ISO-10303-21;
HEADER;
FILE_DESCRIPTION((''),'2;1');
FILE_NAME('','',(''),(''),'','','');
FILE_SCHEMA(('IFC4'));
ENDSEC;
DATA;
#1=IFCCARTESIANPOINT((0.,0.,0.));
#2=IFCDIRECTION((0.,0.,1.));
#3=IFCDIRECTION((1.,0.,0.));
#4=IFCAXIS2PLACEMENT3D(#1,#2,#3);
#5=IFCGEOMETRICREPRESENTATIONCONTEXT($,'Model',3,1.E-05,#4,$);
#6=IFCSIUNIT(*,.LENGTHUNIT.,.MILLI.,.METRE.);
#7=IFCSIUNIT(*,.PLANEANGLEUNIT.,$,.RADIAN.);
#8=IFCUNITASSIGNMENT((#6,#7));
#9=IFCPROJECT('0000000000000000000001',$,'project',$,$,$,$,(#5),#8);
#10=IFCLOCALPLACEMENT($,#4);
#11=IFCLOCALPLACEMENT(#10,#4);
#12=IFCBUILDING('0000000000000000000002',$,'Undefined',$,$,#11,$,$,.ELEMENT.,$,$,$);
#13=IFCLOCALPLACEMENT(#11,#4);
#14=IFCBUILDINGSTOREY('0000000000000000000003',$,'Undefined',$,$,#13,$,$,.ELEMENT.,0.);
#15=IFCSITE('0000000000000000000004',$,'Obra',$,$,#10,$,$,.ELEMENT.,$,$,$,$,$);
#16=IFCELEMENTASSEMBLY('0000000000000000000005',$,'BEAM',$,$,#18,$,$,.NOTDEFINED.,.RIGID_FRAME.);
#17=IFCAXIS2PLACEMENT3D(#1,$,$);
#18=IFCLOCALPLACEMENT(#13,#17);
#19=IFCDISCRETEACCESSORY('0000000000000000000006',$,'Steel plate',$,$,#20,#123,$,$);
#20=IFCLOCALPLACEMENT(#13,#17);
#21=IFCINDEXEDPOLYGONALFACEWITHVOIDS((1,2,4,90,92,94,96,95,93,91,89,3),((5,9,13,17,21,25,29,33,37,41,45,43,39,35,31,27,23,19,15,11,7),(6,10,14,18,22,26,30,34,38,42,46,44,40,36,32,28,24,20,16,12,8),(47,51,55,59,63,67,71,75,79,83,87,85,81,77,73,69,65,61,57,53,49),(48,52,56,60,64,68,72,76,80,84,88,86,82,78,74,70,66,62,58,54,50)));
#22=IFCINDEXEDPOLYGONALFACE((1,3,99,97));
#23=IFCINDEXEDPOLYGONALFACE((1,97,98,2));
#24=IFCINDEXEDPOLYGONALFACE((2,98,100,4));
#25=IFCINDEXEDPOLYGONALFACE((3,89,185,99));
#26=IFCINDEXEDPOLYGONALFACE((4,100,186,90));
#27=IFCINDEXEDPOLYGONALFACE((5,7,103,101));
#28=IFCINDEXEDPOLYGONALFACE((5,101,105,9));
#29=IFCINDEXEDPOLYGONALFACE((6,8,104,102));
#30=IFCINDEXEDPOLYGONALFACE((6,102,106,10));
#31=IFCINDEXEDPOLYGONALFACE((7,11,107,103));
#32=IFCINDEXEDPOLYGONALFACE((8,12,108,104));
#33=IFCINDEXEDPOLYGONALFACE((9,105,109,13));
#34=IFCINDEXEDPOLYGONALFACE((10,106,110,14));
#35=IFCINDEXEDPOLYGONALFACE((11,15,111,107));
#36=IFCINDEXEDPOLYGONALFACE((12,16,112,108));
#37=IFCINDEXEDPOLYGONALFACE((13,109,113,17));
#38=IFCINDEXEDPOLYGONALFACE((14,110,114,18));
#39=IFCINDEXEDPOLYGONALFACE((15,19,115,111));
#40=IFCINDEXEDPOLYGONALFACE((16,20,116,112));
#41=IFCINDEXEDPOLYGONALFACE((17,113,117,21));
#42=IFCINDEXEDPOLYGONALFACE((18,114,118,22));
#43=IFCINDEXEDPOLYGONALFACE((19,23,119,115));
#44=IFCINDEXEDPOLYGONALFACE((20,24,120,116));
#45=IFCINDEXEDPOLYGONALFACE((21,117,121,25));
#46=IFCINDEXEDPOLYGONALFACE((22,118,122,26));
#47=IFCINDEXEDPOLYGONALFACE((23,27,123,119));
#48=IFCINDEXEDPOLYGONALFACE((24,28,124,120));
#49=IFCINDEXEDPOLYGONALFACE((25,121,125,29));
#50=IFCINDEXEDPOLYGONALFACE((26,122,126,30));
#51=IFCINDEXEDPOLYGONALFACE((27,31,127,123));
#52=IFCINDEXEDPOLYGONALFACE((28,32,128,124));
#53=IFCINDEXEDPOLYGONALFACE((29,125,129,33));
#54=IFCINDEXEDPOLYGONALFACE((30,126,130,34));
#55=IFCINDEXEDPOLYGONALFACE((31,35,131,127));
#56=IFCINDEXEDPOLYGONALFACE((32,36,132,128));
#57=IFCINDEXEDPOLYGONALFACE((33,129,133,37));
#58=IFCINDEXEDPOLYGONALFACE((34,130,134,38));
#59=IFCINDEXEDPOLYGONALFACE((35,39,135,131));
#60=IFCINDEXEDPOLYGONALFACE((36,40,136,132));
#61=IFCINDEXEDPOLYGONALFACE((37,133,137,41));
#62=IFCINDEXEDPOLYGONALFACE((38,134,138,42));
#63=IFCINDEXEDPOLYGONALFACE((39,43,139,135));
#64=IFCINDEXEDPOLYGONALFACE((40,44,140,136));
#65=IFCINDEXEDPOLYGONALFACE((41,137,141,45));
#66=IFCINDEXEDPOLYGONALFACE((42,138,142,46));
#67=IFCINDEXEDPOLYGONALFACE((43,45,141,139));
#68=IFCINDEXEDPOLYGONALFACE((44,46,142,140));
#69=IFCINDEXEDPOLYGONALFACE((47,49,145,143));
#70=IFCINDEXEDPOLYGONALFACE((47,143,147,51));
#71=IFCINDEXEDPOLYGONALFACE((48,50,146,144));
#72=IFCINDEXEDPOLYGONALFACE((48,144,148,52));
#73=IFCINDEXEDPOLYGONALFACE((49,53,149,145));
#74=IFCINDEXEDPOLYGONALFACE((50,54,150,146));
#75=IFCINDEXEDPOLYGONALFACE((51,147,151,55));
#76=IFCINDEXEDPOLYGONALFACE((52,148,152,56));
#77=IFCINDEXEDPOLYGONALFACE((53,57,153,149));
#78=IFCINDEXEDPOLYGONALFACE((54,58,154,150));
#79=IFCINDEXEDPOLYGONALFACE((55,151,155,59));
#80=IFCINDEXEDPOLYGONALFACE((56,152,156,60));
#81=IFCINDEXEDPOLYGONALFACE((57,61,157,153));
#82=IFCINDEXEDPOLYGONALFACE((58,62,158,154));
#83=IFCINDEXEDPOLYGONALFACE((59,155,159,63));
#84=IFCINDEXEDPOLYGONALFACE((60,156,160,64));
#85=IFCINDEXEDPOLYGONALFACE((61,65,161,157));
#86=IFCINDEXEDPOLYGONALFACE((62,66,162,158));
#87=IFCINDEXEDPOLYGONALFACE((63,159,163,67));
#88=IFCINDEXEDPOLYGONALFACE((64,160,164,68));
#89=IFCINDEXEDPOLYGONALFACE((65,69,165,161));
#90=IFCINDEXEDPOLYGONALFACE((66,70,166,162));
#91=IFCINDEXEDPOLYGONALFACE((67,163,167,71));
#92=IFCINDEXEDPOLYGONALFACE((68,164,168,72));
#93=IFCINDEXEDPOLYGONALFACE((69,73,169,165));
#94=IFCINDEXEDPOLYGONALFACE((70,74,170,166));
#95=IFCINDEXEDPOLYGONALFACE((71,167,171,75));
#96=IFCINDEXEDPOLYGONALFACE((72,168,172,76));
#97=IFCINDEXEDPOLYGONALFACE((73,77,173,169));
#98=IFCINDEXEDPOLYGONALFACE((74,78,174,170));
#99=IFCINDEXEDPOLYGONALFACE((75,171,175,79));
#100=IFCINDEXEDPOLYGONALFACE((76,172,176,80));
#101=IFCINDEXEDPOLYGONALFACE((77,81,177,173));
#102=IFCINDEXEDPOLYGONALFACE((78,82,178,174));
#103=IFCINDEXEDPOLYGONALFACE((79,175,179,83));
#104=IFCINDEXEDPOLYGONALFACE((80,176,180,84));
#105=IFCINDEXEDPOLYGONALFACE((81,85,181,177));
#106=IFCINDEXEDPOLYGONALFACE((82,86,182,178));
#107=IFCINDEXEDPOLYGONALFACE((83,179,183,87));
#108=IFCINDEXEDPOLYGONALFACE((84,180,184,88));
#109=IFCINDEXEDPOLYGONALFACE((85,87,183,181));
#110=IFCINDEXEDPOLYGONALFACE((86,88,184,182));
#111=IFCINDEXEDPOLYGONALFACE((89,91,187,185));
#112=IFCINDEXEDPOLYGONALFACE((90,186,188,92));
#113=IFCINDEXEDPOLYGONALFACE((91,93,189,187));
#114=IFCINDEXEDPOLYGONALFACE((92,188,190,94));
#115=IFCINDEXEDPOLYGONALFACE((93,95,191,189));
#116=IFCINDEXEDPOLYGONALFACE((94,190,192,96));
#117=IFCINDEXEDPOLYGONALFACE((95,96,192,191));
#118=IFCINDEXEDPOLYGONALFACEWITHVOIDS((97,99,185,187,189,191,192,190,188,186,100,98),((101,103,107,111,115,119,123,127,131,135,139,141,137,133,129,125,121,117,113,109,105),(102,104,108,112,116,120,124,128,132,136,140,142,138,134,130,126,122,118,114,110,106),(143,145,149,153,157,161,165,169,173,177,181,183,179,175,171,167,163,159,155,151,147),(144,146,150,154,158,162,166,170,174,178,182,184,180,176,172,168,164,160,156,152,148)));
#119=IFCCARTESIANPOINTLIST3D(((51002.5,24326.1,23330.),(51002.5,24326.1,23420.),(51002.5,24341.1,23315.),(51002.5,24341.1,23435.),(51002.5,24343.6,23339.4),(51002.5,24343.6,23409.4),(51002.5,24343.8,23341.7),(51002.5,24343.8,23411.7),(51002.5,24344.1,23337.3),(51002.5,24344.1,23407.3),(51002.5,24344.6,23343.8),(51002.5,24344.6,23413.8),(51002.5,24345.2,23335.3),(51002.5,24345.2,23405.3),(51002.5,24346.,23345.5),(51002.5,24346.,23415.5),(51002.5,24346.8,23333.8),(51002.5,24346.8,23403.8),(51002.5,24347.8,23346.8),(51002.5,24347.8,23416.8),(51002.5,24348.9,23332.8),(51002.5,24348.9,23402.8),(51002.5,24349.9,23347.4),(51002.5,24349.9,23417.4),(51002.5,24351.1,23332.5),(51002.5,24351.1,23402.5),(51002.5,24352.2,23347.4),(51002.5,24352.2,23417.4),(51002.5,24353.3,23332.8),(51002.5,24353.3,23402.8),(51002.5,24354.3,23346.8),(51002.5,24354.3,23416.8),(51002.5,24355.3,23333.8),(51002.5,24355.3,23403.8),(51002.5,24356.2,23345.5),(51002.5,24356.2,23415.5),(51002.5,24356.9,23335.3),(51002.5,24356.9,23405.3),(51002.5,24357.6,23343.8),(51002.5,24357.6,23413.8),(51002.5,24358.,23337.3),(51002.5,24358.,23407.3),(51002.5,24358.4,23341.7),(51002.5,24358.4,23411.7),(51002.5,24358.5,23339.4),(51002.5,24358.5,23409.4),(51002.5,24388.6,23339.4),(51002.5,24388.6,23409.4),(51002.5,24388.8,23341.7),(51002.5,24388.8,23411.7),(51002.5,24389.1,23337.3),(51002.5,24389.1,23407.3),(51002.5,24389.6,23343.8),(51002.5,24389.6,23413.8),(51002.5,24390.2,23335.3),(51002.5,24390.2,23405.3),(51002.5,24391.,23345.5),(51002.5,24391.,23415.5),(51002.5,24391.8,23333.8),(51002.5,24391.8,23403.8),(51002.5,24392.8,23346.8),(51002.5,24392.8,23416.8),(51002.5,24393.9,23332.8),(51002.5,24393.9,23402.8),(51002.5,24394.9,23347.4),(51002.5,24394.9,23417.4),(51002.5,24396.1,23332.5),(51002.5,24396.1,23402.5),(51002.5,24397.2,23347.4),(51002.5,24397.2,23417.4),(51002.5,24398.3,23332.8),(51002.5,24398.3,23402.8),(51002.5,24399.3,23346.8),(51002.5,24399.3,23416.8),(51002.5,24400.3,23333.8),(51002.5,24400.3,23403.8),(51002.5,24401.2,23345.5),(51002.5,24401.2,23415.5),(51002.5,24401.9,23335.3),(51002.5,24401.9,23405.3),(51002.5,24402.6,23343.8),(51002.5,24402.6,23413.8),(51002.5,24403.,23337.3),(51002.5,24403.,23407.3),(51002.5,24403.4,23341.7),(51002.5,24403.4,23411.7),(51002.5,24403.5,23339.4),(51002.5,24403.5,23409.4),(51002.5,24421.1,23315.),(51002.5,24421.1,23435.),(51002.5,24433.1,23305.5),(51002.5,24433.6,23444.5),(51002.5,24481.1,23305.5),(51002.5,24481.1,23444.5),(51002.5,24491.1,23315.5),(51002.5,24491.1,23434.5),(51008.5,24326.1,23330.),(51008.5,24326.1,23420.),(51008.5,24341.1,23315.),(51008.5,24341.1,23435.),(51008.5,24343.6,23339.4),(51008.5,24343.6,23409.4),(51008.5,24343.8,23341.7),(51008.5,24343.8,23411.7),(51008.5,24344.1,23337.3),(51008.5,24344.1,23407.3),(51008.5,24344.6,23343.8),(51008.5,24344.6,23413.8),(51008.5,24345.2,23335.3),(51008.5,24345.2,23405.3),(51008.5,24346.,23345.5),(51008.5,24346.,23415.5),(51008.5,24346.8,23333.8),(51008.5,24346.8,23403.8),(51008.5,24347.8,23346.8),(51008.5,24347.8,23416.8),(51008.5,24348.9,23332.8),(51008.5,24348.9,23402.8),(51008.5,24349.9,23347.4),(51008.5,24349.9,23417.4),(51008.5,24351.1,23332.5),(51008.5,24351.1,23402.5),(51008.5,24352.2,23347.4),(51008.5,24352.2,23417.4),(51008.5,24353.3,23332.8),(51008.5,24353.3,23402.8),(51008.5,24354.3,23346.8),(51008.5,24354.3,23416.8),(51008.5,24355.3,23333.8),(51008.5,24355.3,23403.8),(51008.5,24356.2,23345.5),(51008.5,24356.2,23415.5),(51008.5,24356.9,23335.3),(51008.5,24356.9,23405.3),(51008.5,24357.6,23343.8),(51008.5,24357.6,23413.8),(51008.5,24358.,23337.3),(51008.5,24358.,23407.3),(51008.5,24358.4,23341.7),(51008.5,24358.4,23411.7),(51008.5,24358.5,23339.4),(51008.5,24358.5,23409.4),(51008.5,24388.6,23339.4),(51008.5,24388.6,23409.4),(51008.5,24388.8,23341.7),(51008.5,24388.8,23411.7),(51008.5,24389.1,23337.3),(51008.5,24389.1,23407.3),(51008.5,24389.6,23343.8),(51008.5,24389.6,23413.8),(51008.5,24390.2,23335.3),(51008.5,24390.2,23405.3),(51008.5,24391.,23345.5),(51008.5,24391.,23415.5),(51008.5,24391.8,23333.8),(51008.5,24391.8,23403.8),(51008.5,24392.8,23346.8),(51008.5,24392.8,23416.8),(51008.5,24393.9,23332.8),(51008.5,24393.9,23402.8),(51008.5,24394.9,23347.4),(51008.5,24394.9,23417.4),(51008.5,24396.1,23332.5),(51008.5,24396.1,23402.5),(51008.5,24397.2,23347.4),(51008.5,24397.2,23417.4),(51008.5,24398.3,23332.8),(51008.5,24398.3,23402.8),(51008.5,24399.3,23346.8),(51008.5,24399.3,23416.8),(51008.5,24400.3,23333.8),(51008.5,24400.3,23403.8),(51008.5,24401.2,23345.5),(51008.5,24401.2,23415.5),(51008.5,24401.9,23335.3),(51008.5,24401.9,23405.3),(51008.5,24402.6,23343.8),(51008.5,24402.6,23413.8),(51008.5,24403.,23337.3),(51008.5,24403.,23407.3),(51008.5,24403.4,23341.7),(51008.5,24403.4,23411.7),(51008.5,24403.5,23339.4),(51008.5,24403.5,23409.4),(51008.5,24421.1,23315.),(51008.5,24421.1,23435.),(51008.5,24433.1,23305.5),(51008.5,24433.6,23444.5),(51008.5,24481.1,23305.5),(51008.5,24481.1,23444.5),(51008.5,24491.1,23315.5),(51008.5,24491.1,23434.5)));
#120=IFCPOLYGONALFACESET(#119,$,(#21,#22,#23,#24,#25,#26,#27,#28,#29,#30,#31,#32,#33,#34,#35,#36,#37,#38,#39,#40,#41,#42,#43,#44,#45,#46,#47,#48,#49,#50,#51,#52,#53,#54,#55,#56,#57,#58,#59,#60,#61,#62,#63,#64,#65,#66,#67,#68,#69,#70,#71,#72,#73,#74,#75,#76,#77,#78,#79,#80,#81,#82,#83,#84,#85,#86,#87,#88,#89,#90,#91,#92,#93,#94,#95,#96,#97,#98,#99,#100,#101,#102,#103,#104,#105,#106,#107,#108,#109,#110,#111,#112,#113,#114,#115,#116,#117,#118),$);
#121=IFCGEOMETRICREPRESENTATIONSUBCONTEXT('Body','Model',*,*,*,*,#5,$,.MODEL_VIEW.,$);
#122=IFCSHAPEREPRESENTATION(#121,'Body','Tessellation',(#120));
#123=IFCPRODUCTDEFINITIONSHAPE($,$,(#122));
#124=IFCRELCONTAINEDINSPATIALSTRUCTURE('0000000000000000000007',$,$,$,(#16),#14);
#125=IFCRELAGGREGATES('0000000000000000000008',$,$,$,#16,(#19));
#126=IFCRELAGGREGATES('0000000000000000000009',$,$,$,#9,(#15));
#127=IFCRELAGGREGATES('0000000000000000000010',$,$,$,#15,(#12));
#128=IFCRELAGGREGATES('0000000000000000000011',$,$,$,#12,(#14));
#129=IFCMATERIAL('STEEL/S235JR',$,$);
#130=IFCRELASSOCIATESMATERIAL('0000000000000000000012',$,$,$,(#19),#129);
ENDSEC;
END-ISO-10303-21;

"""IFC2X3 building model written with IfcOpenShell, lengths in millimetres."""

from ifc_helpers import new_model, si_unit, frame, origin_with_axes, origin_2d_with_axis, place, context, subcontext, project, spatial, polyline, circle, outline, extrude, source, transform, mapped, material, element, aggregate, save


model = new_model("IFC2X3")

# Units and contexts
model_context = context("Model", 3, precision=1e-05, world=origin_with_axes())
body_context = subcontext(model_context, "Body", "Model", "MODEL_VIEW")
ifc_project = project(units=[si_unit("LENGTHUNIT", "METRE", prefix="MILLI"), si_unit("PLANEANGLEUNIT", "RADIAN")], contexts=[model_context])

# Site, building, storey
site_placement = place(None, origin_with_axes())
site = spatial("IfcSite", under=ifc_project, at=site_placement, Name="Obra", CompositionType="ELEMENT")
building_placement = place(site_placement, origin_with_axes())
building = spatial("IfcBuilding", under=site, at=building_placement, Name="Undefined", CompositionType="ELEMENT")
storey_placement = place(building_placement, origin_with_axes())
storey = spatial("IfcBuildingStorey", under=building, at=storey_placement, Name="Undefined", CompositionType="ELEMENT", Elevation=0.0)

# Shared definitions
ifc_material_1 = material(Name="STEEL/S235JR")

# Element assembly
assembly_1_placement = place(storey_placement, origin_with_axes())
assembly_1 = element("IfcElementAssembly", 1, at=assembly_1_placement, inside=storey, Name="BEAM", AssemblyPlace="NOTDEFINED", PredefinedType="RIGID_FRAME")

# Discrete accessory, opening
discrete_accessory_1_placement = place(assembly_1_placement, frame((51005.5, 24491.1, 23315.5), z_axis=(-1.0, 0.0, 0.0), x_axis=(0.000001, -0.707107, -0.707107)))
discrete_accessory_1 = element("IfcDiscreteAccessory", 2, at=discrete_accessory_1_placement, material=ifc_material_1, Name="Steel plate", context=body_context, shape_type="SweptSolid", body=[
    extrude(outline(polyline([(0.0, 0.0), (14.1, 0.0), (48.1, 33.9), (49.9, 49.1), (106.4, 105.7), (106.4, 126.9), (42.8, 190.6), (21.6, 190.6), (-35.0, 134.0), (-50.6, 131.9), (-84.1, 98.3), (-84.1, 84.1), (0.0, 0.0)])), frame((0.0, 0.0, -3.0), z_axis=(0.0, 0.0, 1.0), x_axis=(1.0, 0.0, 0.0)), (0.0, 0.0, 1.0), 6.0),
])
shared_shape_1 = source(origin_with_axes(), body_context, "Body", "SweptSolid", [
    extrude(circle(Radius=7.5, at=origin_2d_with_axis()), frame((0.0, 2.4, 0.0), z_axis=(0.0, 1.0, 0.0), x_axis=(1.0, 0.0, 0.0)), (0.0, 0.0, 1.0), 6.2),
])
opening_1_placement = place(assembly_1_placement, frame((51000.0, 24373.6, 23410.0), z_axis=(0.0, -1.0, 0.0), x_axis=(0.0, 0.0, -1.0)))
element("IfcOpeningElement", 3, at=opening_1_placement, cuts=discrete_accessory_1, ObjectType="Opening", context=body_context, shape_type="MappedRepresentation", body=[
    mapped(shared_shape_1, transform((0.0, 0.0, -22.5))),
    mapped(shared_shape_1, transform((70.0, 0.0, -22.5))),
    mapped(shared_shape_1, transform((0.0, 0.0, 22.5))),
    mapped(shared_shape_1, transform((70.0, 0.0, 22.5))),
])

aggregate(assembly_1, [discrete_accessory_1])

save(model, "model.ifc")
